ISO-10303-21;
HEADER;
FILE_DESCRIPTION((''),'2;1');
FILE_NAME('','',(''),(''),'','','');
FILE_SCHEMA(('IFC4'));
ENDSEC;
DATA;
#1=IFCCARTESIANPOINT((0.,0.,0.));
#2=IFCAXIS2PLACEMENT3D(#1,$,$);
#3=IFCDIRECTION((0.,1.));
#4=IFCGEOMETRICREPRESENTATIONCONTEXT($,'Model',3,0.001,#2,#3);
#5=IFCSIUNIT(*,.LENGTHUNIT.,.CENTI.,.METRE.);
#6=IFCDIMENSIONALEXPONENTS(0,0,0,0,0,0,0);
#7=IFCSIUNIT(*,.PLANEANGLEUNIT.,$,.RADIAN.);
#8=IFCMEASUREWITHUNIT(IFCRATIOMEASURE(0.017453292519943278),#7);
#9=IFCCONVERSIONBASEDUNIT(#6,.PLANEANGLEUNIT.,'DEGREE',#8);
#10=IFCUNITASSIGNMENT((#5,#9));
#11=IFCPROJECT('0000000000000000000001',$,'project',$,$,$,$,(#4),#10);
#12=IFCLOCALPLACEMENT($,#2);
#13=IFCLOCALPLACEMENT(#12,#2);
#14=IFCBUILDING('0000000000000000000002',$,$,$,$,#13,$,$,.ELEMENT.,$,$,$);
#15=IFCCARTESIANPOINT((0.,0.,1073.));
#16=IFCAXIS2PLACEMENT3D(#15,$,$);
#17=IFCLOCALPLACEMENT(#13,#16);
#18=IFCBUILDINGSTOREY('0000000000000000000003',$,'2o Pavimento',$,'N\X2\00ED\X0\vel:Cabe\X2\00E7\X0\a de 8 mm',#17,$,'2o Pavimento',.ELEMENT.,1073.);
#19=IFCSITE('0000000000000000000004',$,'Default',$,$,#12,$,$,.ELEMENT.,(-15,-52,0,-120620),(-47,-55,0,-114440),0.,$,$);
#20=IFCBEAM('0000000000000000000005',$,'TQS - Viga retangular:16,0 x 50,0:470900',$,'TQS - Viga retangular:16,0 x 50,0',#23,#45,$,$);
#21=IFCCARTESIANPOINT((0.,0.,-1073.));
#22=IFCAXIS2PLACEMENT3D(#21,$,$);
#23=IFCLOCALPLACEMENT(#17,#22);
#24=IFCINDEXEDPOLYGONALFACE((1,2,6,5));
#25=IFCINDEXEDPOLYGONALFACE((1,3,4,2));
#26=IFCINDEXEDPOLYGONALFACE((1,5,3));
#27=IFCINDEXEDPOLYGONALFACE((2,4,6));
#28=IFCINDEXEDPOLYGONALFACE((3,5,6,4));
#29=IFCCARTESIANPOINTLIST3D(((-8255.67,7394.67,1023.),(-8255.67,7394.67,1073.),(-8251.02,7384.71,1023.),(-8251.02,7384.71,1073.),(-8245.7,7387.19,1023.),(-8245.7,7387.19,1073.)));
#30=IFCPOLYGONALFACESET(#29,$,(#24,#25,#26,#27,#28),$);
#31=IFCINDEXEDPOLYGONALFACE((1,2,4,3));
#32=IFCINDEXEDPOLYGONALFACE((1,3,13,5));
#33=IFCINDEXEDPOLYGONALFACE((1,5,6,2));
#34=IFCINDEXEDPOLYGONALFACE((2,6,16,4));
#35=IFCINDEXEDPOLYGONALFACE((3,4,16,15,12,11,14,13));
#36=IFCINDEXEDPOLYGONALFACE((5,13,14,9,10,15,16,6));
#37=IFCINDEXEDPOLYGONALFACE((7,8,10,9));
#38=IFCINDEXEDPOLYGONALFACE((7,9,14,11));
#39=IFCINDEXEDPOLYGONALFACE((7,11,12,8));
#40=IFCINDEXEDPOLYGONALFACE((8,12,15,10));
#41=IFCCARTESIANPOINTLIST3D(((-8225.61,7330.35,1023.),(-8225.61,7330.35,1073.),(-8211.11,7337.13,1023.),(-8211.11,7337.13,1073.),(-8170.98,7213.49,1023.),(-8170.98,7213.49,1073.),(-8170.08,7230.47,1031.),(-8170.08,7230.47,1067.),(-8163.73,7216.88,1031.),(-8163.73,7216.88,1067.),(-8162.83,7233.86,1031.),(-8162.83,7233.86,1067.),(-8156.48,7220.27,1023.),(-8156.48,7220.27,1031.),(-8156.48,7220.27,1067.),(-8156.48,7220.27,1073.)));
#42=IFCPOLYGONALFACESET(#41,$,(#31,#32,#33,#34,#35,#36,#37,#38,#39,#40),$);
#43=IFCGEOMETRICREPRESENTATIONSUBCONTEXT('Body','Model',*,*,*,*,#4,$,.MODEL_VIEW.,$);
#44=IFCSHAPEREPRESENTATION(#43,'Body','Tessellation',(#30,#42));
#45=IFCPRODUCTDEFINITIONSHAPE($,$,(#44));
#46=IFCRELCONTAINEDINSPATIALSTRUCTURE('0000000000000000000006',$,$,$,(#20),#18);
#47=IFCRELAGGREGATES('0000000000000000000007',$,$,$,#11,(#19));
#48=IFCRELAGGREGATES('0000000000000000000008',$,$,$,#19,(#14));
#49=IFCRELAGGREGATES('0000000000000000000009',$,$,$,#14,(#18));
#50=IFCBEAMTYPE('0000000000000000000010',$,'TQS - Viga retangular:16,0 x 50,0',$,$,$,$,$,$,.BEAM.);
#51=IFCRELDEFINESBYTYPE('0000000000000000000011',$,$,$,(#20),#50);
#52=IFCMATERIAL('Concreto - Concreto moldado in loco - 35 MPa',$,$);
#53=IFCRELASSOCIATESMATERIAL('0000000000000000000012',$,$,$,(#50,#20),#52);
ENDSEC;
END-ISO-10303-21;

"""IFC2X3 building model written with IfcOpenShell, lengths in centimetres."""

from ifc_helpers import new_model, entity, si_unit, converted_unit, direction, frame, frame_2d, origin, place, context, subcontext, project, spatial, polyline, rectangle, extrude, boolean, clip, halfspace, bounded_halfspace, source, transform, mapped, material, type_object, type_shapes, element, save


model = new_model("IFC2X3")

# Units and contexts
model_context = context("Model", 3, precision=0.001, world=origin(), true_north=direction((0.0, 1.0)))
body_context = subcontext(model_context, "Body", "Model", "MODEL_VIEW")
ifc_project = project(units=[si_unit("LENGTHUNIT", "METRE", prefix="CENTI"), converted_unit("PLANEANGLEUNIT", "DEGREE", entity("IfcRatioMeasure", 0.017453292519943278), si_unit("PLANEANGLEUNIT", "RADIAN"), dimensions=[0, 0, 0, 0, 0, 0, 0])], contexts=[model_context])

# Site, building, storey
site_placement = place(None, origin())
site = spatial("IfcSite", under=ifc_project, at=site_placement, Name="Default", CompositionType="ELEMENT", RefLatitude=(-15, -52, 0, -120620), RefLongitude=(-47, -55, 0, -114440), RefElevation=0.0)
building_placement = place(site_placement, origin())
building = spatial("IfcBuilding", under=site, at=building_placement, CompositionType="ELEMENT")
storey_placement = place(building_placement, frame((0.0, 0.0, 1073.0)))
storey = spatial("IfcBuildingStorey", under=building, at=storey_placement, Name="2o Pavimento", ObjectType="Nível:Cabeça de 8 mm", LongName="2o Pavimento", CompositionType="ELEMENT", Elevation=1073.0)

# Shared definitions
ifc_material = material(Name="Concreto - Concreto moldado in loco - 35 MPa")

# Beam
beam_type_1 = type_object("IfcBeamType", Name="TQS - Viga retangular:16,0 x 50,0", PredefinedType="BEAM", material=ifc_material)
shared_shape_1 = source(origin(), body_context, "Body", "SweptSolid", [
    clip(extrude(rectangle(XDim=50.0, YDim=5.87, at=frame_2d((0.0, 0.0), x_axis=(1.0, 0.0))), frame((-8248.36, 7385.95, 1048.0), z_axis=(-0.423488, 0.905902, 0.0), x_axis=(0.0, 0.0, 1.0)), (0.0, 0.0, 1.0), 11.0), halfspace(frame((-8228.47, 7374.27, 1073.0), z_axis=(0.600037, 0.799972, 0.0), x_axis=(0.799972, -0.600037, 0.0)), False)),
    boolean("DIFFERENCE", clip(extrude(rectangle(XDim=50.0, YDim=16.0, at=frame_2d((0.0, 0.0), x_axis=(1.0, 0.0))), frame((-8163.73, 7216.88, 1048.0), z_axis=(-0.423488, 0.905902, 0.0), x_axis=(0.0, 0.0, 1.0)), (0.0, 0.0, 1.0), 129.0), bounded_halfspace(frame((-7535.95, 7526.91, 1031.0), z_axis=(0.423488, -0.905902, 0.0), x_axis=(-0.905902, -0.423488, 0.0)), False, frame((-8163.73, 7216.88, 1048.0), z_axis=(-0.423488, 0.905902, 0.0), x_axis=(0.0, 0.0, 1.0)), polyline([(19.0, 0.0), (-17.0, 0.0), (-17.0, 8.0), (9.0, 8.0), (19.0, 8.0), (19.0, 0.0)]))), extrude(rectangle(XDim=36.0, YDim=8.0, at=frame_2d((0.0, 0.0), x_axis=(0.0, 1.0))), frame((-8166.46, 7232.16, 1049.0), z_axis=(-0.423488, 0.905902, 0.0), x_axis=(-0.905902, -0.423488, 0.0)), (0.0, 0.0, -1.0), 15.0)),
])
type_shapes(beam_type_1, [shared_shape_1])
beam_1_placement = place(storey_placement, frame((0.0, 0.0, -1073.0)))
element("IfcBeam", 1, at=beam_1_placement, inside=storey, type_object=beam_type_1, material=ifc_material, Name="TQS - Viga retangular:16,0 x 50,0:470900", ObjectType="TQS - Viga retangular:16,0 x 50,0", context=body_context, shape_type="MappedRepresentation", body=[
    mapped(shared_shape_1, transform((0.0, 0.0, 0.0), scale=1.0)),
])

save(model, "model.ifc")
